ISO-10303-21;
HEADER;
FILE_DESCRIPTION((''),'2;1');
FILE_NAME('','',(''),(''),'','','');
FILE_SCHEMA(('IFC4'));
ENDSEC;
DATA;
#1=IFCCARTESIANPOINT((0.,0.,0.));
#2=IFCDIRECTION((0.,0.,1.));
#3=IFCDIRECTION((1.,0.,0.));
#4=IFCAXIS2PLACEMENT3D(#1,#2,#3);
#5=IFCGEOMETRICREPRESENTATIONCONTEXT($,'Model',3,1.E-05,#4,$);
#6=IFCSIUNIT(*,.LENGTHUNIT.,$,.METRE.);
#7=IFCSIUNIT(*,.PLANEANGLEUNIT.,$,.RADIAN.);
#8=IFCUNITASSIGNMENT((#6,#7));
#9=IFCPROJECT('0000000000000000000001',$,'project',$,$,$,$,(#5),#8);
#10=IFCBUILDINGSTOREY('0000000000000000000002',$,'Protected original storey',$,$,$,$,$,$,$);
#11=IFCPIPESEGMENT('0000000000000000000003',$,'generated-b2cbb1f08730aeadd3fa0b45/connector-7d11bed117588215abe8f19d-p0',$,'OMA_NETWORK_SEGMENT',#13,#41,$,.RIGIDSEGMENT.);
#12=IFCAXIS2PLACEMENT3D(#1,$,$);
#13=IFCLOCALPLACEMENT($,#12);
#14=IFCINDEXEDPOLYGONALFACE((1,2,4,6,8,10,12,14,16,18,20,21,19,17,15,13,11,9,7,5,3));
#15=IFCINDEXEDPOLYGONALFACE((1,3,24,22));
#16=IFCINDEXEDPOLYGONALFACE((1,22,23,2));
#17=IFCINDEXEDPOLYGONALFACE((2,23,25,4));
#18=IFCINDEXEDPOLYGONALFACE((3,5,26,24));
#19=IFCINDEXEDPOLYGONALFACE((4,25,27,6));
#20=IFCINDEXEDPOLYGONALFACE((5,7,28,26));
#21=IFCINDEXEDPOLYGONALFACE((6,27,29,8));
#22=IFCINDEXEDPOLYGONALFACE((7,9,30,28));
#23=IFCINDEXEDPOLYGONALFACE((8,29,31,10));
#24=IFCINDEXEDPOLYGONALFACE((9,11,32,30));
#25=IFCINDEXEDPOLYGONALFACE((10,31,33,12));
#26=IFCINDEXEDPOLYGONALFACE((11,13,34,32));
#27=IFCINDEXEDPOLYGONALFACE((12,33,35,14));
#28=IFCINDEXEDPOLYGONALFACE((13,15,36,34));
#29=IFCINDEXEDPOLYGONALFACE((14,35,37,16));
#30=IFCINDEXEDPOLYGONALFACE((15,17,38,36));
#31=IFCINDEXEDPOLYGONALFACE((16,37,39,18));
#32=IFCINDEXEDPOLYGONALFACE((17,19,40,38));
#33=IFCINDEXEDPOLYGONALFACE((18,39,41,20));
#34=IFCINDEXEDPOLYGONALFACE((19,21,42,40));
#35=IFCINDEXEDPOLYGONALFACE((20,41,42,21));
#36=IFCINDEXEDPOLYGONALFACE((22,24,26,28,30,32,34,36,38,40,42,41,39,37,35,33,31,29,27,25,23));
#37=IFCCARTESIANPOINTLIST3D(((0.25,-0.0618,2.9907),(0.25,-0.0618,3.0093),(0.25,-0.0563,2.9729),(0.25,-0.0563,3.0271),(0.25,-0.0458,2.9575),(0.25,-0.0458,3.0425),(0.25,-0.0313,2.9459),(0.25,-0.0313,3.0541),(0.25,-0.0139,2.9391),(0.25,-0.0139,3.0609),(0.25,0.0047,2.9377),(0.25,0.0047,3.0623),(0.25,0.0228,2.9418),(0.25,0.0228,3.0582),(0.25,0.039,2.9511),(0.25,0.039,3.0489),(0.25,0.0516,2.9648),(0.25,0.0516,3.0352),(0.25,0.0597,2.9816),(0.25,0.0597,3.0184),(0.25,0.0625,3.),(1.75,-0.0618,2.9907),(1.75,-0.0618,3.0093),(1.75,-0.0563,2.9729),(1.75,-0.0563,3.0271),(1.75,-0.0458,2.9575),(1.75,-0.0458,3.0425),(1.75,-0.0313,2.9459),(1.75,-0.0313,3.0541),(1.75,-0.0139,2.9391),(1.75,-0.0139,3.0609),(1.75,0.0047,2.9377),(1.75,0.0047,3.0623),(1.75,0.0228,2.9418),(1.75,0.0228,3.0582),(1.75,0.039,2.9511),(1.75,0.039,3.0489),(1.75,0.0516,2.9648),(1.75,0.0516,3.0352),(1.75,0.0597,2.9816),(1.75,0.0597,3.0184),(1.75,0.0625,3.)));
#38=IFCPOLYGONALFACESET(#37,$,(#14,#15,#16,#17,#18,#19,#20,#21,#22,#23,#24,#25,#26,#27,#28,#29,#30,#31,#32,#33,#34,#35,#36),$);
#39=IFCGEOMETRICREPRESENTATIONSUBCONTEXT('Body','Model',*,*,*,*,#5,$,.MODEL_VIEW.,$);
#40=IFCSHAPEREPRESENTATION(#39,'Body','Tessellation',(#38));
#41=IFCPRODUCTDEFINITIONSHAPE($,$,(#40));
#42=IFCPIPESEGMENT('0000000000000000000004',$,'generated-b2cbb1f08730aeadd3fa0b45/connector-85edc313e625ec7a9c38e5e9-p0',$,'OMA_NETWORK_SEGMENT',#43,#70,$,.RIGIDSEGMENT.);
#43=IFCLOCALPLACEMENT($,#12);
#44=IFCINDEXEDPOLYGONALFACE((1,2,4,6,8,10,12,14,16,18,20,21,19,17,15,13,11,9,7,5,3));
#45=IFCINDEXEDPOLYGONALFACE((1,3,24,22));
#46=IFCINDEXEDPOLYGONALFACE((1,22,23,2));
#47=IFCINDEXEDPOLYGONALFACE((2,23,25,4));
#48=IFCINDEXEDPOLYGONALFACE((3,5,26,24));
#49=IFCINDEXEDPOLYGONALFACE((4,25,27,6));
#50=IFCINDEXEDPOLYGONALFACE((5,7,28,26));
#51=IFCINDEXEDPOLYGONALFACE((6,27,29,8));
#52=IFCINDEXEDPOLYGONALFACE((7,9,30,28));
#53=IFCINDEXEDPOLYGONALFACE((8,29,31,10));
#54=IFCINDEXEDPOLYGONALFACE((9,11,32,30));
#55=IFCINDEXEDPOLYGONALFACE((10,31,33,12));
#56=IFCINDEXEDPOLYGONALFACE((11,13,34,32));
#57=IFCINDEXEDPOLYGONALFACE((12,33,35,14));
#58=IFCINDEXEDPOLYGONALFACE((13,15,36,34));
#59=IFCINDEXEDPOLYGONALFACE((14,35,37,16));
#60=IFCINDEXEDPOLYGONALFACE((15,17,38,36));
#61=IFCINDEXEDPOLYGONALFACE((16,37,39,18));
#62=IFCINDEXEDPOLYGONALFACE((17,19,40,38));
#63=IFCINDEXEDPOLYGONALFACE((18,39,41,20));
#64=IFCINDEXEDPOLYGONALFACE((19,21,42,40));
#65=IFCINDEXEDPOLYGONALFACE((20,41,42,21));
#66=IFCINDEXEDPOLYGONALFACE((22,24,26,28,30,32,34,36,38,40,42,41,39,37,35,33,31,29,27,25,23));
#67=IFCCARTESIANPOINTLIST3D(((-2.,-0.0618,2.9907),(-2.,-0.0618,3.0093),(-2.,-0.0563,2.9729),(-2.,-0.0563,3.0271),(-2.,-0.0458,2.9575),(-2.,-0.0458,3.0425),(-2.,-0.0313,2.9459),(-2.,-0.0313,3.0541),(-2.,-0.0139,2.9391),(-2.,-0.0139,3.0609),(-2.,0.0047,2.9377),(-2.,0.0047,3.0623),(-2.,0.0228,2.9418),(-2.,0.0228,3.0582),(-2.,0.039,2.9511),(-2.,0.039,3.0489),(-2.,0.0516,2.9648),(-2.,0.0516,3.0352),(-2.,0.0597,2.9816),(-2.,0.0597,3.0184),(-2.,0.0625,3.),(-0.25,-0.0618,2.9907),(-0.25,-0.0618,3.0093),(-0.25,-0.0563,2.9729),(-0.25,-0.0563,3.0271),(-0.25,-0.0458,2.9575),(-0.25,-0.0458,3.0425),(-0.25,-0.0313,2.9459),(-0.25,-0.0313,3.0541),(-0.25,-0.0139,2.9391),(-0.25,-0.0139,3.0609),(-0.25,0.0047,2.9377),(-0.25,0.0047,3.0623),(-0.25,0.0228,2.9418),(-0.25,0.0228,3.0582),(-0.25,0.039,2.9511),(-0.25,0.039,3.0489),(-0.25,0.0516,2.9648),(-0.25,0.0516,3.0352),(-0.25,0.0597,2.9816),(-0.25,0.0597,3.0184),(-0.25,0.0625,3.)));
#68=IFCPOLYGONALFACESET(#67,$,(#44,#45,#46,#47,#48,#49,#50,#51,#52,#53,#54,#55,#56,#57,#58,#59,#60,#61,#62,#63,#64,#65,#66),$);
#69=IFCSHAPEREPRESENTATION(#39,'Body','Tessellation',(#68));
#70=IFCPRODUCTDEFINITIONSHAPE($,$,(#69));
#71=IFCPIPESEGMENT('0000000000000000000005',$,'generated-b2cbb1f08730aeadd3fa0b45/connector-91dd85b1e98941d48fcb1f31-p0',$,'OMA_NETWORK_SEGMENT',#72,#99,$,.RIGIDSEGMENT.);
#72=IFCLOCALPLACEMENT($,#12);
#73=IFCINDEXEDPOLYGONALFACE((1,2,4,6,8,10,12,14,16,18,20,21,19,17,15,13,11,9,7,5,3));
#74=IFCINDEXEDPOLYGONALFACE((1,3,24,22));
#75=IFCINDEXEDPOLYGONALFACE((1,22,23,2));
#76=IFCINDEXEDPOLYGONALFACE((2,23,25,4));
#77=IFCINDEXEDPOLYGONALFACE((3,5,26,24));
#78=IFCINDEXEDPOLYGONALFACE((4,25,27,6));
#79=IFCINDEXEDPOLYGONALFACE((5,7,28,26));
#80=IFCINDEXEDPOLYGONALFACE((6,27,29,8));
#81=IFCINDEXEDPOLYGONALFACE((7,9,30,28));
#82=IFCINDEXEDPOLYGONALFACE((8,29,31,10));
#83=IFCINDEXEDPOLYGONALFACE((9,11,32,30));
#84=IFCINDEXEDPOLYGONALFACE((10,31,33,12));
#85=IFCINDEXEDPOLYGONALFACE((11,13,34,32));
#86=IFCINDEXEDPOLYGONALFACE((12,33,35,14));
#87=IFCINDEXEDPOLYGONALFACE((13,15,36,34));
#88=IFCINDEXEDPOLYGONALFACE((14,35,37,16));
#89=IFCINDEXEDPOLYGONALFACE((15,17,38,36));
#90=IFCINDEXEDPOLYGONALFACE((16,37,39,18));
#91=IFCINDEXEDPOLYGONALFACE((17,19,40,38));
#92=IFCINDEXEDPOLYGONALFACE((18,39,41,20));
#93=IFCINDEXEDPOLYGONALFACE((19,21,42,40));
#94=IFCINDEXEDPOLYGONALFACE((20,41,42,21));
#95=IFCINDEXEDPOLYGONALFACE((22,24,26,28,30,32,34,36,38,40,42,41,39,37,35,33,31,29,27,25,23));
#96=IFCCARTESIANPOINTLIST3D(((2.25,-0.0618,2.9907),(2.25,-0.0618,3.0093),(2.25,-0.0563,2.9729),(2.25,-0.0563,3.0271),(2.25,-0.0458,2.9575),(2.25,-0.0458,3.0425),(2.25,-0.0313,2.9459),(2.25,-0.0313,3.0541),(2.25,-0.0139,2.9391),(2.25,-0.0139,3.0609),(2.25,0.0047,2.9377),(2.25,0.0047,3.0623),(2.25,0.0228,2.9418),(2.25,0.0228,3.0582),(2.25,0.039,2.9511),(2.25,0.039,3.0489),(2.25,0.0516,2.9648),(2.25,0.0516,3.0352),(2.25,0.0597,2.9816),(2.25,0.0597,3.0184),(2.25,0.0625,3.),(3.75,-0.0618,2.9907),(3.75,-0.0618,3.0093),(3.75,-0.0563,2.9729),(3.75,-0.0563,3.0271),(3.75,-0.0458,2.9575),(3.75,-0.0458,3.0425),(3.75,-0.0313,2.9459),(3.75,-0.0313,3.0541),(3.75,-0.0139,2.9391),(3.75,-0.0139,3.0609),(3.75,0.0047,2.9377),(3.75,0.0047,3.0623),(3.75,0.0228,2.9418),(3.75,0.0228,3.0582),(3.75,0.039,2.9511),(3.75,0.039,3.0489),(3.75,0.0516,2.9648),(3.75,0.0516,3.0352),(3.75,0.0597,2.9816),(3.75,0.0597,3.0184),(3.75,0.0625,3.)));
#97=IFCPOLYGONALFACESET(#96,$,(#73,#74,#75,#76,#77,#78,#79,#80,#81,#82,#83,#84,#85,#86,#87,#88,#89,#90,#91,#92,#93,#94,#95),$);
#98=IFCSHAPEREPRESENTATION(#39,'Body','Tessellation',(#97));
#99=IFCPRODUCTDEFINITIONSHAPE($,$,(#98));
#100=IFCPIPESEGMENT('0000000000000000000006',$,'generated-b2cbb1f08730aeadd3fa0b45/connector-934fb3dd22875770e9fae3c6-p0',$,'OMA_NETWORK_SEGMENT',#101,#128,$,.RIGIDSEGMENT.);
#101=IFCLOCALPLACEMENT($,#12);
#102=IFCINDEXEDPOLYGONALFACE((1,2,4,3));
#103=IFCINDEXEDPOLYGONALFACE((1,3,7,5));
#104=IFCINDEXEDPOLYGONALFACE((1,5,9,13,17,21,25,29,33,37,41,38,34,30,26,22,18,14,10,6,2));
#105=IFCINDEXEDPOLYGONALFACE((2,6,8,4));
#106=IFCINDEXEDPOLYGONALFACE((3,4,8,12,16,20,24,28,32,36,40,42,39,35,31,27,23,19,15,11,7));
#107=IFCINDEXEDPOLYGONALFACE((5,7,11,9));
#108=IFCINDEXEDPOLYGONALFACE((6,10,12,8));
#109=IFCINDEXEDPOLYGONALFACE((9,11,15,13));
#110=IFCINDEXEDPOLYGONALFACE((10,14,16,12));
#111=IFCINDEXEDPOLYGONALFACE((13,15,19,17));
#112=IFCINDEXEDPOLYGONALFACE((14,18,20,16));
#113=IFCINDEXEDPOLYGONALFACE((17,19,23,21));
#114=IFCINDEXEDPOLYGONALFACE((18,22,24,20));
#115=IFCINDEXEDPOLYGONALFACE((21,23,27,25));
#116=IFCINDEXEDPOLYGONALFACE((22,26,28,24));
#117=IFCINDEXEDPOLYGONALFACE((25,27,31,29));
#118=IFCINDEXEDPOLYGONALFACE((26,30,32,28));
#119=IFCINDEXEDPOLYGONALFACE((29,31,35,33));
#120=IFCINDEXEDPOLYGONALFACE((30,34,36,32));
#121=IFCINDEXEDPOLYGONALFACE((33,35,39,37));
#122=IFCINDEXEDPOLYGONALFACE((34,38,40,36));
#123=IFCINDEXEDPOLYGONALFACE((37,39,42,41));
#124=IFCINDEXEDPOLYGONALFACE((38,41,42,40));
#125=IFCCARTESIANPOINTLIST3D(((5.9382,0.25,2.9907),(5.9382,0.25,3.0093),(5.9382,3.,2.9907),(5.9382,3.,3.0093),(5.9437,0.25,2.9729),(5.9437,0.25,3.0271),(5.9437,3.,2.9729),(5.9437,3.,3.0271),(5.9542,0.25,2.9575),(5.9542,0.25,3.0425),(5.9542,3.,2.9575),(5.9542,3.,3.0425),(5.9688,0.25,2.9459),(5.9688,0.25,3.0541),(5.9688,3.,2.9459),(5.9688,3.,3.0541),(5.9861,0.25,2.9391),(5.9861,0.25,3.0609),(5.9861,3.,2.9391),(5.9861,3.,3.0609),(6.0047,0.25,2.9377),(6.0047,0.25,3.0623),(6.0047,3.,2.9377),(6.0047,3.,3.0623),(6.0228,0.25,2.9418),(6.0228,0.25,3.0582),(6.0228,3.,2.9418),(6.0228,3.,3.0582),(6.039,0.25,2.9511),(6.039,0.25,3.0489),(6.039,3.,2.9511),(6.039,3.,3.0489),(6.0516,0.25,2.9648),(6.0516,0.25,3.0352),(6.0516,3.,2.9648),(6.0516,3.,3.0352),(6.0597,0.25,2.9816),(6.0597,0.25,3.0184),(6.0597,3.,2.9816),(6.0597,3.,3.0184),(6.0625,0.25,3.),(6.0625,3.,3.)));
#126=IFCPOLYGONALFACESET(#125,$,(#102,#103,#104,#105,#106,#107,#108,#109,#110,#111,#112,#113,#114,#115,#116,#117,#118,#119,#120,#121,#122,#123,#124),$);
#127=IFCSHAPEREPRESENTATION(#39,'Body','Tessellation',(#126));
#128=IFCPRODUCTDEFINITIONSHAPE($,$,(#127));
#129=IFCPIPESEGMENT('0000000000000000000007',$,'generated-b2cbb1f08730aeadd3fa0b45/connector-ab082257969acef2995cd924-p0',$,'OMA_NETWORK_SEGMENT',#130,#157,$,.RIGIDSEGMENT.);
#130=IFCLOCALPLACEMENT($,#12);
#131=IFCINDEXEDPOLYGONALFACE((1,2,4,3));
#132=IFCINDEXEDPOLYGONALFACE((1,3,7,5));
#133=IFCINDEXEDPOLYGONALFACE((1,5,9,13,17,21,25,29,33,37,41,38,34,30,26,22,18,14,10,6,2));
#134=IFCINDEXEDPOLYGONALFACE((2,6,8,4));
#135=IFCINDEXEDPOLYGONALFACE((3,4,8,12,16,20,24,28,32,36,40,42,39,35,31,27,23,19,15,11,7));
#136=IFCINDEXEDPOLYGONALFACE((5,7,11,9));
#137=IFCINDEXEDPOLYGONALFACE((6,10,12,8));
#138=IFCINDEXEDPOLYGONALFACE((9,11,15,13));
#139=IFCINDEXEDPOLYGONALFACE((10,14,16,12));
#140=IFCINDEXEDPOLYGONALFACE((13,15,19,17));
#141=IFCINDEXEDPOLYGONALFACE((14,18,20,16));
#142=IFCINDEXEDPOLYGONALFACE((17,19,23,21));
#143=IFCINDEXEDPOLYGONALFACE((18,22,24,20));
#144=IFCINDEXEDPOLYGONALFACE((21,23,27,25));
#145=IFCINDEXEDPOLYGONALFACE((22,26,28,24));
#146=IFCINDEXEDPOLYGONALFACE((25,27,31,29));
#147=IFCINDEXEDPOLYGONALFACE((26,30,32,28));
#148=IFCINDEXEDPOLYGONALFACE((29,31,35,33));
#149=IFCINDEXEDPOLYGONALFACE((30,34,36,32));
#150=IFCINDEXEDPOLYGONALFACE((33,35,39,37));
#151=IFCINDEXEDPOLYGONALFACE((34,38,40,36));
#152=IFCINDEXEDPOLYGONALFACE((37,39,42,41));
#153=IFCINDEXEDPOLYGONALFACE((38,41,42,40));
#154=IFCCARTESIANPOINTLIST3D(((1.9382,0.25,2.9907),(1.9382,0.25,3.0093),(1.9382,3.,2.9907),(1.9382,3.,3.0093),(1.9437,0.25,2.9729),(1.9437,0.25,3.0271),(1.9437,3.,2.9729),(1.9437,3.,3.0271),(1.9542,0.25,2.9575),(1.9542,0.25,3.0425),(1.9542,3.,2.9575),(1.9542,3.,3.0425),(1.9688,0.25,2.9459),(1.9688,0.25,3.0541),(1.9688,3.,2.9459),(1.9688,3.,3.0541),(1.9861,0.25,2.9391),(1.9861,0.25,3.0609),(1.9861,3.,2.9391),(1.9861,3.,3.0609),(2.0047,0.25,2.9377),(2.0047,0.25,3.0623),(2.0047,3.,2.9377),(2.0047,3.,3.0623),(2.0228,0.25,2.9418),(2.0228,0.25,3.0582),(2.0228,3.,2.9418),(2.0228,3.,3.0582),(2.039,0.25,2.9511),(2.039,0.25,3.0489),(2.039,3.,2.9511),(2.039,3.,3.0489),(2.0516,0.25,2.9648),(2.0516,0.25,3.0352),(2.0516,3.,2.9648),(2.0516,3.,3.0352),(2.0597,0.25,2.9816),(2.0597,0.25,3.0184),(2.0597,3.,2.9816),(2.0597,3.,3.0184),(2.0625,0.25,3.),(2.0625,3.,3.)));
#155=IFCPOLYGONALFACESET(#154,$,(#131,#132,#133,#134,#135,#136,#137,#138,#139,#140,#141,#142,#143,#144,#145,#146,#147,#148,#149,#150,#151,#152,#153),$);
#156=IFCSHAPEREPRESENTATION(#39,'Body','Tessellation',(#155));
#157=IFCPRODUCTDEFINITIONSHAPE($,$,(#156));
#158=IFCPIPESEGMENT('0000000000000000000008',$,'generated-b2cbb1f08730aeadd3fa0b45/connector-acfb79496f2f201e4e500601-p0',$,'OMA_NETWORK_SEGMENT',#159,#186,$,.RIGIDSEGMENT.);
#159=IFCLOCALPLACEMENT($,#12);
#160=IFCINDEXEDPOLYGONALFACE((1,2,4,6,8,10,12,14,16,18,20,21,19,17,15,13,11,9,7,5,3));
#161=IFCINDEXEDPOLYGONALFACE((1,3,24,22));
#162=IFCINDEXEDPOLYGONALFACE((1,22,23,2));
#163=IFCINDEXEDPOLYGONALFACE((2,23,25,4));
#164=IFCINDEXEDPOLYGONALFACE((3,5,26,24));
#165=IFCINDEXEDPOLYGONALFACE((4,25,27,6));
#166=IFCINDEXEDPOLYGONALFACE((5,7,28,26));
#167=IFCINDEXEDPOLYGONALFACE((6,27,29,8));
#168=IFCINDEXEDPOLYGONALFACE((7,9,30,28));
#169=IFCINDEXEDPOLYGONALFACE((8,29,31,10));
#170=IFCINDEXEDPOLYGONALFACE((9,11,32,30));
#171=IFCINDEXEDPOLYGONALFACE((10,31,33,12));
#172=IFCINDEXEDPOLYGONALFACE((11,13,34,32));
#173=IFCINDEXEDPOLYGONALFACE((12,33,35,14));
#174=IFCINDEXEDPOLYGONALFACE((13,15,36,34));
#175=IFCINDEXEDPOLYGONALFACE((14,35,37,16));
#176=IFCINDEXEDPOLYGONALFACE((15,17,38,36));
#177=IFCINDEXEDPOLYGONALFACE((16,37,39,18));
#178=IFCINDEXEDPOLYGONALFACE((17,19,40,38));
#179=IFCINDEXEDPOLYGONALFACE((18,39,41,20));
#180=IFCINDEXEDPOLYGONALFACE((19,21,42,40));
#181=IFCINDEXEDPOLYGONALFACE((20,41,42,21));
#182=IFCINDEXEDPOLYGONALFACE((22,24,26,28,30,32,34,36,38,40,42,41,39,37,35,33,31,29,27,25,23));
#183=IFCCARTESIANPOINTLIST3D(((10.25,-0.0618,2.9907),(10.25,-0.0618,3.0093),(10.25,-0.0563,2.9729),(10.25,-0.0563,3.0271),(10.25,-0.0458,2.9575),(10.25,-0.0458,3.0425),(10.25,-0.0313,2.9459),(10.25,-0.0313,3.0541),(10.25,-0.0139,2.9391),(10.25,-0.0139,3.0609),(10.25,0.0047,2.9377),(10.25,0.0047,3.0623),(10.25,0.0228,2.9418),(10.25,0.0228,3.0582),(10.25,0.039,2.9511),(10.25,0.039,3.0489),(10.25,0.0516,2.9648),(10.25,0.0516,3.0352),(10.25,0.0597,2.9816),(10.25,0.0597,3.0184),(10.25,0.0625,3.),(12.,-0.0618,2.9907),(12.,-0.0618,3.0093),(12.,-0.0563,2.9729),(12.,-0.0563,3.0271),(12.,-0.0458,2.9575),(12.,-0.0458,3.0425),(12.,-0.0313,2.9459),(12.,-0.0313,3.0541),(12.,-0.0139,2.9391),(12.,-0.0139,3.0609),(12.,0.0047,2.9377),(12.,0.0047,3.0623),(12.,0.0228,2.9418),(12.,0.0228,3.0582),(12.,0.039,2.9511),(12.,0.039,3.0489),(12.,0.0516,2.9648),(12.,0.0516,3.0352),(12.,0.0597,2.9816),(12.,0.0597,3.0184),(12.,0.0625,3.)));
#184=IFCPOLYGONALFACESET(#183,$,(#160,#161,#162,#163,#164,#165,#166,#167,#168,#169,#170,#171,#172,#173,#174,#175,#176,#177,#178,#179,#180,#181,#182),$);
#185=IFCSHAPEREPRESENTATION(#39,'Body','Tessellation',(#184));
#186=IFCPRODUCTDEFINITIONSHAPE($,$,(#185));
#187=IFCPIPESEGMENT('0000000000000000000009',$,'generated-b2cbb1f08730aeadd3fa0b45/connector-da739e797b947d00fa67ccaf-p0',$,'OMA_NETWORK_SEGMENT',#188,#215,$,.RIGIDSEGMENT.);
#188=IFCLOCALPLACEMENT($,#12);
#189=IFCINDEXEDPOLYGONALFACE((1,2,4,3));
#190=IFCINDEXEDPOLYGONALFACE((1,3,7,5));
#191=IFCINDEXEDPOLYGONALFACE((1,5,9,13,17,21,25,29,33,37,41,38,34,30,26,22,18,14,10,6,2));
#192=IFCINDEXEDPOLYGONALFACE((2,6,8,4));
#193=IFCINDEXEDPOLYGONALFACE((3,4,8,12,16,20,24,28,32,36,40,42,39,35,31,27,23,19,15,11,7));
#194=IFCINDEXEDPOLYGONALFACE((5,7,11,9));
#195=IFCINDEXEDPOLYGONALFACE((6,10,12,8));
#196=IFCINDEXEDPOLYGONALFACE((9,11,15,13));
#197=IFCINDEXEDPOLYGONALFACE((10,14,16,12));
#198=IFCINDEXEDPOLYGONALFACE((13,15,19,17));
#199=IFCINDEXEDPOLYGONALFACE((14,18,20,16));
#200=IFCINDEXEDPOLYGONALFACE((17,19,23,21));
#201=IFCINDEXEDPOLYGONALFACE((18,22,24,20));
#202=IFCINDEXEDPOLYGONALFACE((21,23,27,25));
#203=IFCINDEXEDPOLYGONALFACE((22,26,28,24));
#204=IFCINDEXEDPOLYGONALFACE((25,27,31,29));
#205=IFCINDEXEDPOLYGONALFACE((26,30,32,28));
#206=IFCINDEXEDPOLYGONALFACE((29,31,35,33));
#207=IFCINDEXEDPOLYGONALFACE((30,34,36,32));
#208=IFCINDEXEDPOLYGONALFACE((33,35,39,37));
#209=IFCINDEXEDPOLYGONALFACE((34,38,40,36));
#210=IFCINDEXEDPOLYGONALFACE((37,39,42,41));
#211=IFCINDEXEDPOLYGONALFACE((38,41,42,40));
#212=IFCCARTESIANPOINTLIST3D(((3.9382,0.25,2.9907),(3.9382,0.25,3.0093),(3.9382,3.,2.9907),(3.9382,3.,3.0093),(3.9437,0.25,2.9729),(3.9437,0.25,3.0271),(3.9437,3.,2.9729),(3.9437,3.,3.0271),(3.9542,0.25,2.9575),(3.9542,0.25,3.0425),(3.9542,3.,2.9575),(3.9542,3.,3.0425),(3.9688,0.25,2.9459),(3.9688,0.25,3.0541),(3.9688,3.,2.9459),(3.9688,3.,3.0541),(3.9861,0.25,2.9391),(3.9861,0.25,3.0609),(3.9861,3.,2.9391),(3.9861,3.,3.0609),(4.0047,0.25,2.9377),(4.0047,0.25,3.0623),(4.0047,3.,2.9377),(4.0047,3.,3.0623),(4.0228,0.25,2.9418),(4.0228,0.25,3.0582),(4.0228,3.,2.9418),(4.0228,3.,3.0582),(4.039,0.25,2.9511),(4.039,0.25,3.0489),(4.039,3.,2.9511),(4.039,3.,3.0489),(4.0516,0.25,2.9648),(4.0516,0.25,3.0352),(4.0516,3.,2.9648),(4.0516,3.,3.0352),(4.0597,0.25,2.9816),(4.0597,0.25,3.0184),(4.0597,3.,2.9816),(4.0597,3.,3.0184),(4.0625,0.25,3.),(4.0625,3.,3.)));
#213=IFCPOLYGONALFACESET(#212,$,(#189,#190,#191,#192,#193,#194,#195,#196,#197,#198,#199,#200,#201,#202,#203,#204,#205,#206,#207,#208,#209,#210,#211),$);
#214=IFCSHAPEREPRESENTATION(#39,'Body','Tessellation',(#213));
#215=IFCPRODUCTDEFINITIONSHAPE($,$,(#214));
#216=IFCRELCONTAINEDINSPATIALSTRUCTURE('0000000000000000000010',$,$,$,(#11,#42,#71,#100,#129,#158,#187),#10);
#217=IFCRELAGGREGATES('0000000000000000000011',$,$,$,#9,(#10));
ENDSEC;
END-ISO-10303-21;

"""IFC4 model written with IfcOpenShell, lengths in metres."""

from ifc_helpers import new_model, si_unit, frame, origin_with_axes, origin_2d, place, context, subcontext, project, spatial, circle, extrude, element, save


model = new_model("IFC4")

# Units and contexts
model_context = context("Model", 3, precision=1e-05, world=origin_with_axes())
body_context = subcontext(model_context, "Body", "Model", "MODEL_VIEW")
ifc_project = project(units=[si_unit("LENGTHUNIT", "METRE"), si_unit("PLANEANGLEUNIT", "RADIAN")], contexts=[model_context])

# Storey
storey = spatial("IfcBuildingStorey", under=ifc_project, Name="Protected original storey")

# Pipe segments
pipe_segment_1_placement = place(None, origin_with_axes())
element("IfcPipeSegment", 1, at=pipe_segment_1_placement, inside=storey, Name="generated-b2cbb1f08730aeadd3fa0b45/connector-7d11bed117588215abe8f19d-p0", ObjectType="OMA_NETWORK_SEGMENT", PredefinedType="RIGIDSEGMENT", context=body_context, shape_type="SweptSolid", body=[
    extrude(circle(Radius=0.0625, at=origin_2d()), frame((0.25, 0.0, 3.0), z_axis=(1.0, 0.0, 0.0), x_axis=(0.0, 1.0, 0.0)), (0.0, 0.0, 1.0), 1.5),
])
pipe_segment_2_placement = place(None, origin_with_axes())
element("IfcPipeSegment", 2, at=pipe_segment_2_placement, inside=storey, Name="generated-b2cbb1f08730aeadd3fa0b45/connector-85edc313e625ec7a9c38e5e9-p0", ObjectType="OMA_NETWORK_SEGMENT", PredefinedType="RIGIDSEGMENT", context=body_context, shape_type="SweptSolid", body=[
    extrude(circle(Radius=0.0625, at=origin_2d()), frame((-2.0, 0.0, 3.0), z_axis=(1.0, 0.0, 0.0), x_axis=(0.0, 1.0, 0.0)), (0.0, 0.0, 1.0), 1.75),
])
pipe_segment_3_placement = place(None, origin_with_axes())
element("IfcPipeSegment", 3, at=pipe_segment_3_placement, inside=storey, Name="generated-b2cbb1f08730aeadd3fa0b45/connector-91dd85b1e98941d48fcb1f31-p0", ObjectType="OMA_NETWORK_SEGMENT", PredefinedType="RIGIDSEGMENT", context=body_context, shape_type="SweptSolid", body=[
    extrude(circle(Radius=0.0625, at=origin_2d()), frame((2.25, 0.0, 3.0), z_axis=(1.0, 0.0, 0.0), x_axis=(0.0, 1.0, 0.0)), (0.0, 0.0, 1.0), 1.5),
])
pipe_segment_4_placement = place(None, origin_with_axes())
element("IfcPipeSegment", 4, at=pipe_segment_4_placement, inside=storey, Name="generated-b2cbb1f08730aeadd3fa0b45/connector-934fb3dd22875770e9fae3c6-p0", ObjectType="OMA_NETWORK_SEGMENT", PredefinedType="RIGIDSEGMENT", context=body_context, shape_type="SweptSolid", body=[
    extrude(circle(Radius=0.0625, at=origin_2d()), frame((6.0, 0.25, 3.0), z_axis=(0.0, 1.0, 0.0), x_axis=(1.0, 0.0, 0.0)), (0.0, 0.0, 1.0), 2.75),
])
pipe_segment_5_placement = place(None, origin_with_axes())
element("IfcPipeSegment", 5, at=pipe_segment_5_placement, inside=storey, Name="generated-b2cbb1f08730aeadd3fa0b45/connector-ab082257969acef2995cd924-p0", ObjectType="OMA_NETWORK_SEGMENT", PredefinedType="RIGIDSEGMENT", context=body_context, shape_type="SweptSolid", body=[
    extrude(circle(Radius=0.0625, at=origin_2d()), frame((2.0, 0.25, 3.0), z_axis=(0.0, 1.0, 0.0), x_axis=(1.0, 0.0, 0.0)), (0.0, 0.0, 1.0), 2.75),
])
pipe_segment_6_placement = place(None, origin_with_axes())
element("IfcPipeSegment", 6, at=pipe_segment_6_placement, inside=storey, Name="generated-b2cbb1f08730aeadd3fa0b45/connector-acfb79496f2f201e4e500601-p0", ObjectType="OMA_NETWORK_SEGMENT", PredefinedType="RIGIDSEGMENT", context=body_context, shape_type="SweptSolid", body=[
    extrude(circle(Radius=0.0625, at=origin_2d()), frame((10.25, 0.0, 3.0), z_axis=(1.0, 0.0, 0.0), x_axis=(0.0, 1.0, 0.0)), (0.0, 0.0, 1.0), 1.75),
])
pipe_segment_7_placement = place(None, origin_with_axes())
element("IfcPipeSegment", 7, at=pipe_segment_7_placement, inside=storey, Name="generated-b2cbb1f08730aeadd3fa0b45/connector-da739e797b947d00fa67ccaf-p0", ObjectType="OMA_NETWORK_SEGMENT", PredefinedType="RIGIDSEGMENT", context=body_context, shape_type="SweptSolid", body=[
    extrude(circle(Radius=0.0625, at=origin_2d()), frame((4.0, 0.25, 3.0), z_axis=(0.0, 1.0, 0.0), x_axis=(1.0, 0.0, 0.0)), (0.0, 0.0, 1.0), 2.75),
])

save(model, "model.ifc")
